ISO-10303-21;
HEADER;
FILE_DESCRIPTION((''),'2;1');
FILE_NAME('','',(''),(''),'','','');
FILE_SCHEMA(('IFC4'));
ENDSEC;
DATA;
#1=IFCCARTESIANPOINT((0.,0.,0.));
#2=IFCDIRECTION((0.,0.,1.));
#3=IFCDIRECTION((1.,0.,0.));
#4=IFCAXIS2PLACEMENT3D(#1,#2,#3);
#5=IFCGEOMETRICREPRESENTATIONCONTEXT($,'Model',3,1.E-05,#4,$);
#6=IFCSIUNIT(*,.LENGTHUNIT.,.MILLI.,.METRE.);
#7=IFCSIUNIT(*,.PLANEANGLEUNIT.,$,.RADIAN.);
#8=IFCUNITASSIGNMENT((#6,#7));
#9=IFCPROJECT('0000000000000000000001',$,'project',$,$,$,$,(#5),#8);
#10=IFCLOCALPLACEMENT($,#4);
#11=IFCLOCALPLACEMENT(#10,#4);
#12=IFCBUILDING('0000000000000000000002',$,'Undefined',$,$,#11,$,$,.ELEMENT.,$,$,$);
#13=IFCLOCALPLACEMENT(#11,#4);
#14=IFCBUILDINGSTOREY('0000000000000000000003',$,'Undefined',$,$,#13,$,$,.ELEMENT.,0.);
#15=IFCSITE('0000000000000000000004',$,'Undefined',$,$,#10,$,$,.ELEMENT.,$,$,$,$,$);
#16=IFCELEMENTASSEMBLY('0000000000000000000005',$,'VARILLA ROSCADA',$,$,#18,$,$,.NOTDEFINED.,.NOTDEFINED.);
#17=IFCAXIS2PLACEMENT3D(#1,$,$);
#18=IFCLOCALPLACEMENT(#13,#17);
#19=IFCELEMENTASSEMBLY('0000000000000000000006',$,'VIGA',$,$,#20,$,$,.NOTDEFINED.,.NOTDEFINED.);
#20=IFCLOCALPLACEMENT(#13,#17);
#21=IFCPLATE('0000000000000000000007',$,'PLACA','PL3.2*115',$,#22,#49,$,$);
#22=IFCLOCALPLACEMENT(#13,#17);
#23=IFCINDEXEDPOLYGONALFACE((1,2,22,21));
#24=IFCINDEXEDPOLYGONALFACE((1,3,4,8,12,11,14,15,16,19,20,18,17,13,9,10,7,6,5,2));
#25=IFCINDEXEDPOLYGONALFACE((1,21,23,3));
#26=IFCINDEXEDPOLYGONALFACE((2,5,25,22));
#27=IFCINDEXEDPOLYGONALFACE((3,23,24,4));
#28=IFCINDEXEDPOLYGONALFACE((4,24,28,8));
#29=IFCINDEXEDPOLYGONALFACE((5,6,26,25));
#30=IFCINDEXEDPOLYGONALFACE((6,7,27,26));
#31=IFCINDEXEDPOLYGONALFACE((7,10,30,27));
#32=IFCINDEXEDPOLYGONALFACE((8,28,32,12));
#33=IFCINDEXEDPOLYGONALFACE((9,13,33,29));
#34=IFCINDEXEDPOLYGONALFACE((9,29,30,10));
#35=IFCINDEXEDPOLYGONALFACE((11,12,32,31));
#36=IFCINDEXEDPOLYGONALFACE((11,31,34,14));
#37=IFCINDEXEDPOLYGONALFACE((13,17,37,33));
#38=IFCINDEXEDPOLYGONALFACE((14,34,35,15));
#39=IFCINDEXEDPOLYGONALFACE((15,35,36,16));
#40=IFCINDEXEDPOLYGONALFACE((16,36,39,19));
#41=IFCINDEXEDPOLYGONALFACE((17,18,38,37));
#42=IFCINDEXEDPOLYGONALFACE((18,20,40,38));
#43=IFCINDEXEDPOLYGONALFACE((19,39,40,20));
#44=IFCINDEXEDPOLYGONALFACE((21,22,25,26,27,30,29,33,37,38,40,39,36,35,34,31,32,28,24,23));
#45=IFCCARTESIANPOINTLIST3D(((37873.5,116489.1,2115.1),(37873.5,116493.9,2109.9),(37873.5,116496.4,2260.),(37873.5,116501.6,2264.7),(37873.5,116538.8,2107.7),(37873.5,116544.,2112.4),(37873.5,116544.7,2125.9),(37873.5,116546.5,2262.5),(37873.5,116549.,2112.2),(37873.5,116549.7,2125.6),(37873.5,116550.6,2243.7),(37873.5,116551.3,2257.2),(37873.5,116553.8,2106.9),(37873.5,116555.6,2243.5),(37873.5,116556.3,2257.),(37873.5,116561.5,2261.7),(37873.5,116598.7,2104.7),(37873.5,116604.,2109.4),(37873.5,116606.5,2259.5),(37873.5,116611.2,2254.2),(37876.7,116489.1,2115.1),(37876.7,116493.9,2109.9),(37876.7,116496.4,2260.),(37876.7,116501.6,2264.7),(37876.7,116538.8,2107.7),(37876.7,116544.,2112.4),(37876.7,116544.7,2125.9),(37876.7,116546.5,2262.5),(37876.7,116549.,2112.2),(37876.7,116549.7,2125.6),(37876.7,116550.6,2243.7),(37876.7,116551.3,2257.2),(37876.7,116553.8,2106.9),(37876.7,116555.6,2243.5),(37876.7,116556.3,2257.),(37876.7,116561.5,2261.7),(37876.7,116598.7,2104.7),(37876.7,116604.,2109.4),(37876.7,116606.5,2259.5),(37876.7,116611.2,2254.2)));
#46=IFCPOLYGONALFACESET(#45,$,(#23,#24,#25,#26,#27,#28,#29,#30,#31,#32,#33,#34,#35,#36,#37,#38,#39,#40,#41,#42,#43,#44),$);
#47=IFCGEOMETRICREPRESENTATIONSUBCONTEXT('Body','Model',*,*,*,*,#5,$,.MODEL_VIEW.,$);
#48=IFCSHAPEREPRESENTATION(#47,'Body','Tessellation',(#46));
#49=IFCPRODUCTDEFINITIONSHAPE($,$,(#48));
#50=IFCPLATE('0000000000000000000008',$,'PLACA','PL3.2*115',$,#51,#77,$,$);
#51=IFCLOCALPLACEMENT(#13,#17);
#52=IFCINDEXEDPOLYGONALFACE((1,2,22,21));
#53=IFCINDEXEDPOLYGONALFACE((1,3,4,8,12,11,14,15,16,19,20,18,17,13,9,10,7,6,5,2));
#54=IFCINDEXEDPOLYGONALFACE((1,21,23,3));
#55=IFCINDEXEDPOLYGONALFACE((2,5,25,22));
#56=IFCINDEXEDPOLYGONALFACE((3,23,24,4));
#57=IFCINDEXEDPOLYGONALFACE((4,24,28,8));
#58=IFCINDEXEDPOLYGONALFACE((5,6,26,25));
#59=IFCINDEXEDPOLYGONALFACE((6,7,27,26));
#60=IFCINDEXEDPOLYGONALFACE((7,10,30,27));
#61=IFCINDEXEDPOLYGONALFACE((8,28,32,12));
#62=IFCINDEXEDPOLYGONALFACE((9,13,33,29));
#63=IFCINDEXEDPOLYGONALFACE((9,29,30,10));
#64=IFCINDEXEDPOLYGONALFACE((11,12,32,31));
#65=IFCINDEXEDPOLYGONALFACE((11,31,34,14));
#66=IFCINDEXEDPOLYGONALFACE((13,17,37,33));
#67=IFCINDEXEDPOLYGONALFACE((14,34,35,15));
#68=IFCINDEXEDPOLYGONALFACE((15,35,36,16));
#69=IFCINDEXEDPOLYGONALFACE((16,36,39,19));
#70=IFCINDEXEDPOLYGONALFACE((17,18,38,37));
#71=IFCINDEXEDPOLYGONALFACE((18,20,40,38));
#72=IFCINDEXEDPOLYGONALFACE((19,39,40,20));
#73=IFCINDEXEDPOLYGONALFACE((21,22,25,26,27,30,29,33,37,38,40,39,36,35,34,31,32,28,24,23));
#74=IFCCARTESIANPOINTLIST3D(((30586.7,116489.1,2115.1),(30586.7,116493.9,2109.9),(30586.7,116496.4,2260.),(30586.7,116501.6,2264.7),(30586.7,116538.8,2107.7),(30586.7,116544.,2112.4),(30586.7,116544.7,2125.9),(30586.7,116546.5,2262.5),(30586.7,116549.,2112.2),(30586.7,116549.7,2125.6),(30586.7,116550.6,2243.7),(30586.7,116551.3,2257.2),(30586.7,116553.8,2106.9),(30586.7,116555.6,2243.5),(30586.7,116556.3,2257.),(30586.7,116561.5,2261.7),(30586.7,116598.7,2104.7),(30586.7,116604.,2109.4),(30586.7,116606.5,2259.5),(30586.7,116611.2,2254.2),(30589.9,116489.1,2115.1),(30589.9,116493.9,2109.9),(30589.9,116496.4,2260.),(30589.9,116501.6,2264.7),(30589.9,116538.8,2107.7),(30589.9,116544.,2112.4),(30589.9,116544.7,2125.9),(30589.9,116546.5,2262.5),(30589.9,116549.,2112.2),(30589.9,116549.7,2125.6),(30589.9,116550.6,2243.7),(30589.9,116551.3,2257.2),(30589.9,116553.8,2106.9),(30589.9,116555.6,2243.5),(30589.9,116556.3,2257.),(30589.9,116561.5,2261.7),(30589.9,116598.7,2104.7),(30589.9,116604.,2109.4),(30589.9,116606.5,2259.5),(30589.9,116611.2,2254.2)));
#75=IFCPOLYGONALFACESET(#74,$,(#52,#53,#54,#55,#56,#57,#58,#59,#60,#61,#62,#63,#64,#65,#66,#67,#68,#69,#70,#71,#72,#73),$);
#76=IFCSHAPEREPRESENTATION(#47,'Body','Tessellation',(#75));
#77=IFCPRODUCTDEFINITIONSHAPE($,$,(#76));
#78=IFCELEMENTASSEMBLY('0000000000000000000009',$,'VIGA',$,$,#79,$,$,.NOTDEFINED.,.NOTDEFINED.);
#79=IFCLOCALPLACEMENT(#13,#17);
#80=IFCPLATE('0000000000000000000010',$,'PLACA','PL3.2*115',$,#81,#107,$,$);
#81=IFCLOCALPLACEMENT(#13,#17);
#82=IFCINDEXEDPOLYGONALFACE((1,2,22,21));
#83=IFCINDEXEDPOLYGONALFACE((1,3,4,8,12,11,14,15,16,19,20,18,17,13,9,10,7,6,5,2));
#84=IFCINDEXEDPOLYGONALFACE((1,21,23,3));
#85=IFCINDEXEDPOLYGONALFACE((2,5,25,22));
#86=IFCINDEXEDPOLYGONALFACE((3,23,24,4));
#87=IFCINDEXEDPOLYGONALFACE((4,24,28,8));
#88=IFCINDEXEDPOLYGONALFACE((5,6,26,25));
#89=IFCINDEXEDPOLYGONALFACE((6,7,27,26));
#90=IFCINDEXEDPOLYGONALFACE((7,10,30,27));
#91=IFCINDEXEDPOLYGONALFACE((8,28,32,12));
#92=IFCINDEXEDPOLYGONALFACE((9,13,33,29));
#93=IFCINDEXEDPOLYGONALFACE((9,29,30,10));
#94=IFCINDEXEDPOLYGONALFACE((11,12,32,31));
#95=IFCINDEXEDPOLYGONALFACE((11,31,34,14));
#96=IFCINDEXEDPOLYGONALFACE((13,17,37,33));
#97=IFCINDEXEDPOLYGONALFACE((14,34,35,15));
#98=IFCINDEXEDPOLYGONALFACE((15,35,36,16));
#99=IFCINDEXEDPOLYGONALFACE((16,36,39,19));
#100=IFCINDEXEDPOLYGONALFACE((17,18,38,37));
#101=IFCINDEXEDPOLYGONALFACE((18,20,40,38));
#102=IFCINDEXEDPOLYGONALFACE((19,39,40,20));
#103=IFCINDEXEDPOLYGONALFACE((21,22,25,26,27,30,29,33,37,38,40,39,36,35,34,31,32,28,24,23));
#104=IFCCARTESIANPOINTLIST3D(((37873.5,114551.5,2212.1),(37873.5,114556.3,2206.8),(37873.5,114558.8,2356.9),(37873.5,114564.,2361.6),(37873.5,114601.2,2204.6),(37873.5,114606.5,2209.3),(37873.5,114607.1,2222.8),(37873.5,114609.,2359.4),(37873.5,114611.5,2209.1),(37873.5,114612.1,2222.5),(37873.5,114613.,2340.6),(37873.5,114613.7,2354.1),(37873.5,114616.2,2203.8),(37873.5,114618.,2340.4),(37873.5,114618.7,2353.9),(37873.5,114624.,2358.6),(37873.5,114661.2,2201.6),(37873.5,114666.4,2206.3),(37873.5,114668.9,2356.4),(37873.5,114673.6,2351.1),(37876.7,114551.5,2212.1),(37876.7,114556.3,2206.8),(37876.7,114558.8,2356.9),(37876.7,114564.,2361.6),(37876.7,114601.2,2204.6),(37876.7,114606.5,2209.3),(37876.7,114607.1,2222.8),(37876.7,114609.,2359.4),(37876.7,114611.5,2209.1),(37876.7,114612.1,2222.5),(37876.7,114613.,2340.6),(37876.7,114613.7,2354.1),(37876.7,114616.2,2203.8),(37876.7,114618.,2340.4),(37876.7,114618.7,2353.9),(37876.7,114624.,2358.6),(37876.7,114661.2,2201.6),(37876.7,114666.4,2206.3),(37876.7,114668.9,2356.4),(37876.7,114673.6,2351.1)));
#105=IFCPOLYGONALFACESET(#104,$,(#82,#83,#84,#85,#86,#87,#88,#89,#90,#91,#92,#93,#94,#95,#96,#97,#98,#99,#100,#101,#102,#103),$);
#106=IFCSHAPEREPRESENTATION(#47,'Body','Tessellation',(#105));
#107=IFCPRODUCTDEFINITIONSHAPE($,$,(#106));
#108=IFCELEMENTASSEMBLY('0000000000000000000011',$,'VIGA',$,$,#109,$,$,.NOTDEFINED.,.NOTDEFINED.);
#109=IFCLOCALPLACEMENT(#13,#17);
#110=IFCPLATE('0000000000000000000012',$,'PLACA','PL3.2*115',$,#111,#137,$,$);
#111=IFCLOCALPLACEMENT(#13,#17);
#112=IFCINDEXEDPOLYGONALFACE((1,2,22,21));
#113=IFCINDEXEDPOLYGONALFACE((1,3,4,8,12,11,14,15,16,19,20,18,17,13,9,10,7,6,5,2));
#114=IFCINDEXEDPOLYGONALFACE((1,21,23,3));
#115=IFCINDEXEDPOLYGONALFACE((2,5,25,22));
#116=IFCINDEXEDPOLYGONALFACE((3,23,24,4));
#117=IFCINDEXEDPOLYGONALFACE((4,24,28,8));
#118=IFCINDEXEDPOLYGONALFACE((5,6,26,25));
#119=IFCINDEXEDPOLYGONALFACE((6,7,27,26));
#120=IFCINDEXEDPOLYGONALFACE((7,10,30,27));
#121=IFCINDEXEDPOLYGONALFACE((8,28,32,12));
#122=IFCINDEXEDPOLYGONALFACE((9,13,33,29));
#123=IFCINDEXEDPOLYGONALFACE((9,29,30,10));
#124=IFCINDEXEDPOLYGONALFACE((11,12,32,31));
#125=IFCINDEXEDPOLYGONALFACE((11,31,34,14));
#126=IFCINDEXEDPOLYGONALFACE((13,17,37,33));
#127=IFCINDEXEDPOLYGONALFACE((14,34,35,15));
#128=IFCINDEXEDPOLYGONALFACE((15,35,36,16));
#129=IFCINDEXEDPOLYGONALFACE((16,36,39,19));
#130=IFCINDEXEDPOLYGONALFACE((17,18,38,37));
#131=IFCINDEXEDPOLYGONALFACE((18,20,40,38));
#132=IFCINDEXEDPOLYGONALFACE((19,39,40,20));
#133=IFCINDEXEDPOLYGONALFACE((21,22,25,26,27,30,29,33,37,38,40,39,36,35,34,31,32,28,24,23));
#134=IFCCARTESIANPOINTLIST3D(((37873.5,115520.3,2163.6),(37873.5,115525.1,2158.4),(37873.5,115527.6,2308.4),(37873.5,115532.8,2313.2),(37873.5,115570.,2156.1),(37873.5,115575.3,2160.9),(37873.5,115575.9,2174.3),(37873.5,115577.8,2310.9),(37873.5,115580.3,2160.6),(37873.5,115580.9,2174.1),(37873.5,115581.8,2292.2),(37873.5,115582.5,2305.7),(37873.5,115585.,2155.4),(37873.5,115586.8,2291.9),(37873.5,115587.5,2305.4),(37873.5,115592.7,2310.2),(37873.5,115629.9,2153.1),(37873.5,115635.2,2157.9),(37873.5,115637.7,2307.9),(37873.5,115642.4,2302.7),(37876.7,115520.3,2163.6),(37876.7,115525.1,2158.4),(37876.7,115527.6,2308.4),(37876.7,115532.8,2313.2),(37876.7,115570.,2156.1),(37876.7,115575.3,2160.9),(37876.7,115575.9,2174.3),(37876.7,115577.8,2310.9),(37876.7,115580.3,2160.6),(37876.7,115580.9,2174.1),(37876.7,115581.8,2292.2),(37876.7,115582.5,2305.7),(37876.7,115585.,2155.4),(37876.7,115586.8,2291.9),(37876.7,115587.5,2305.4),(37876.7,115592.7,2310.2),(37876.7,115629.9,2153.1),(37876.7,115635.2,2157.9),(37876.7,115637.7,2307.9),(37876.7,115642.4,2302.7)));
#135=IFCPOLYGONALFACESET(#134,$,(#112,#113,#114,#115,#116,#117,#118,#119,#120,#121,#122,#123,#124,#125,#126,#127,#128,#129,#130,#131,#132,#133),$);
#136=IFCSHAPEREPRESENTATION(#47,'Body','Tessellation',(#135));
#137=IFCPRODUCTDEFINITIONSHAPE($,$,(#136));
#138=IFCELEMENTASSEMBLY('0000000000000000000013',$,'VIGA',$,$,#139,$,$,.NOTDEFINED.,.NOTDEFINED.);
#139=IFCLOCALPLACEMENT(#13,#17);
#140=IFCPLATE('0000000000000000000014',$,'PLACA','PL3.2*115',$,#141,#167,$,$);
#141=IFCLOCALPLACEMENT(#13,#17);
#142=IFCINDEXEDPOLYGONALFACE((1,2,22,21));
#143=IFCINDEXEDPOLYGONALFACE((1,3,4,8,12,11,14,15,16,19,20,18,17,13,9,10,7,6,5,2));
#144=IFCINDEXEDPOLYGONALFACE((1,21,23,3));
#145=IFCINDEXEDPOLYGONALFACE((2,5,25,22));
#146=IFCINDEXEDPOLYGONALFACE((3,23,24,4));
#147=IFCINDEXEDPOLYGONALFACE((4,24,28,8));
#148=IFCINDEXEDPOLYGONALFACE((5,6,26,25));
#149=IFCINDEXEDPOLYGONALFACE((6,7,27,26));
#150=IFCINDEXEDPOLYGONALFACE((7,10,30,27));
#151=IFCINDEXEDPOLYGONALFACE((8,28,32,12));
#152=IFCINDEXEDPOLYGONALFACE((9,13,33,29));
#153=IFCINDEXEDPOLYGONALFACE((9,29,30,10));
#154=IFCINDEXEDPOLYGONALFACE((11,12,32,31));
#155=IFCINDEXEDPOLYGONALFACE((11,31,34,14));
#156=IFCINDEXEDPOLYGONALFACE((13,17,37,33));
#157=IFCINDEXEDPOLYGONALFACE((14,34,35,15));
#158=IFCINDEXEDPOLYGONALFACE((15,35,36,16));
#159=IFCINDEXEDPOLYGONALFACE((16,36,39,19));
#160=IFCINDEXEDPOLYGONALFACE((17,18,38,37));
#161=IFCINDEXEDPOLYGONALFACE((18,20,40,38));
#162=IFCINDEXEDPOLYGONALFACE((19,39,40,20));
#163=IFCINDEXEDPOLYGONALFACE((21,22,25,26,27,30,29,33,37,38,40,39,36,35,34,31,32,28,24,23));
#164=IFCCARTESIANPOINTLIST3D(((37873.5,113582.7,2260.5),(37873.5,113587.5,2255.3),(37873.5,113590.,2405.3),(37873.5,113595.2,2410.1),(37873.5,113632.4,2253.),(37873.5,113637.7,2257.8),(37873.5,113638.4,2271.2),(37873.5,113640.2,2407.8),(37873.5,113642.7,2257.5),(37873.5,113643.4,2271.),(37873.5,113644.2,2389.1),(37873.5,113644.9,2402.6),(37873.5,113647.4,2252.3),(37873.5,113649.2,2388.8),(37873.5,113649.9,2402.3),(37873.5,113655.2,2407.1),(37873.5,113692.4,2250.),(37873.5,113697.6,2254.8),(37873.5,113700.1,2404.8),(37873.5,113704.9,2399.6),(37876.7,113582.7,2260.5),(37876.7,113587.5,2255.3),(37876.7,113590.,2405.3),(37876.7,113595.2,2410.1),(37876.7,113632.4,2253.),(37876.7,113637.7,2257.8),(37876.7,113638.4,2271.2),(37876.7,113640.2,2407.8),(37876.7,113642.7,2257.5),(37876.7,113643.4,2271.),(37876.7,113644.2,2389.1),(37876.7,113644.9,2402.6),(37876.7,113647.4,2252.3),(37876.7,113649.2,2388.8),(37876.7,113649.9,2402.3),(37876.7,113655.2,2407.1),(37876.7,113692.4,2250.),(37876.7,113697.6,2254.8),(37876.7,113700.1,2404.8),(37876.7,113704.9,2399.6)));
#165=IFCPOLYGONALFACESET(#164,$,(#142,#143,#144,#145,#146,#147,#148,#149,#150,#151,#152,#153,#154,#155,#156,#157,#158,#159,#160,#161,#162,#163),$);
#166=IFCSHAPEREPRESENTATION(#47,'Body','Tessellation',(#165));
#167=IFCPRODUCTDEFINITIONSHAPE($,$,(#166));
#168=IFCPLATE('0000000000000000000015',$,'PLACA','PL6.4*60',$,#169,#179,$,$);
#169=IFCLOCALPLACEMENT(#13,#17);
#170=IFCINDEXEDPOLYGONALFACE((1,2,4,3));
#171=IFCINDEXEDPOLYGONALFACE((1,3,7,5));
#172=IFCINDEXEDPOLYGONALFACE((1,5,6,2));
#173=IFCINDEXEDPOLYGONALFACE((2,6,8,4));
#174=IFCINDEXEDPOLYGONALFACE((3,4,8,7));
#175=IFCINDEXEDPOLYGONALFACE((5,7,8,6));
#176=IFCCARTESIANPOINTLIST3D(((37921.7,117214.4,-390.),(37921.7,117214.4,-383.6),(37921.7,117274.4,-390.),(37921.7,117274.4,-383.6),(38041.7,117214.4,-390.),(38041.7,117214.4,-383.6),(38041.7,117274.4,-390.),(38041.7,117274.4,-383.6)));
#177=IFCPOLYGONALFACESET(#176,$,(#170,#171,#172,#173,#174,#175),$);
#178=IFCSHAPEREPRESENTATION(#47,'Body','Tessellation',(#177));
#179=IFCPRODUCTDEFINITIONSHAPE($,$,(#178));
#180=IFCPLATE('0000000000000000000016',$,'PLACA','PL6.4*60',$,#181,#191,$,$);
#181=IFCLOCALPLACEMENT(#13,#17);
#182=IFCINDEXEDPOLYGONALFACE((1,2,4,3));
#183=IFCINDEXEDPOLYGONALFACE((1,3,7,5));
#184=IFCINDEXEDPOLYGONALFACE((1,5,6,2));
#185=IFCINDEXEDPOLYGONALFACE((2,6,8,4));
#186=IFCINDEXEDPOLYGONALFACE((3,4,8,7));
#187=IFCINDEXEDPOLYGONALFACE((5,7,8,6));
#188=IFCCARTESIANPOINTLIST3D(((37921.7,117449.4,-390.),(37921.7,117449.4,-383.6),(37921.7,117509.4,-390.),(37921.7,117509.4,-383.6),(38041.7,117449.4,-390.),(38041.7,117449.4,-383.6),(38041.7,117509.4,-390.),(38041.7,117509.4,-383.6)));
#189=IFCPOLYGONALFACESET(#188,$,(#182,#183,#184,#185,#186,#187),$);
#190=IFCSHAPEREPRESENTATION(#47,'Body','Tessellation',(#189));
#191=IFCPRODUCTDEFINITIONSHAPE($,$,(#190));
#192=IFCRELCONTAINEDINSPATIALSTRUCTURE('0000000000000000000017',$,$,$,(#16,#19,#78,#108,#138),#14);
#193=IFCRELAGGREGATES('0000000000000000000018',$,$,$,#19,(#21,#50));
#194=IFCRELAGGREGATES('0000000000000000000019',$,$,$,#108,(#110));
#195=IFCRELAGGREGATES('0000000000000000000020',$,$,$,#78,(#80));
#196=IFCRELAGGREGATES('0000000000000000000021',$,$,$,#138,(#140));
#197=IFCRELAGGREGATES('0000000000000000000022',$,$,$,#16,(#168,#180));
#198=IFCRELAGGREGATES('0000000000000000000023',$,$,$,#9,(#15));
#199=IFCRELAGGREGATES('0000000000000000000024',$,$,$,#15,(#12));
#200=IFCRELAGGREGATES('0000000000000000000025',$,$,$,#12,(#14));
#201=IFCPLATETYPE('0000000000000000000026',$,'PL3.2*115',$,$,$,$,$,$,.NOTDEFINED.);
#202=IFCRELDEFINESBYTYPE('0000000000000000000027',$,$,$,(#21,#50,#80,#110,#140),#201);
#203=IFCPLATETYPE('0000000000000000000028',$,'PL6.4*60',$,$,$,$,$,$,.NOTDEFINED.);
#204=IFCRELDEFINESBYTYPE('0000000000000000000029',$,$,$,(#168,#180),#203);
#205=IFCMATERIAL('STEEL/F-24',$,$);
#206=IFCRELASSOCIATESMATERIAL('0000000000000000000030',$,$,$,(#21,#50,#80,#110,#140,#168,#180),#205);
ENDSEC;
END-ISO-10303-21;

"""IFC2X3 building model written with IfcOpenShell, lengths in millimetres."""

from ifc_helpers import new_model, si_unit, frame, origin_with_axes, place, context, subcontext, project, spatial, polyline, outline, extrude, material, type_object, element, aggregate, save


model = new_model("IFC2X3")

# Units and contexts
model_context = context("Model", 3, precision=1e-05, world=origin_with_axes())
body_context = subcontext(model_context, "Body", "Model", "MODEL_VIEW")
ifc_project = project(units=[si_unit("LENGTHUNIT", "METRE", prefix="MILLI"), si_unit("PLANEANGLEUNIT", "RADIAN")], contexts=[model_context])

# Site, building, storey
site_placement = place(None, origin_with_axes())
site = spatial("IfcSite", under=ifc_project, at=site_placement, Name="Undefined", CompositionType="ELEMENT")
building_placement = place(site_placement, origin_with_axes())
building = spatial("IfcBuilding", under=site, at=building_placement, Name="Undefined", CompositionType="ELEMENT")
storey_placement = place(building_placement, origin_with_axes())
storey = spatial("IfcBuildingStorey", under=building, at=storey_placement, Name="Undefined", CompositionType="ELEMENT", Elevation=0.0)

# Element assembly
assembly_1_placement = place(storey_placement, origin_with_axes())
assembly_1 = element("IfcElementAssembly", 1, at=assembly_1_placement, inside=storey, Name="VARILLA ROSCADA", AssemblyPlace="NOTDEFINED", PredefinedType="NOTDEFINED")

# Shared definitions
ifc_material_1 = material(Name="STEEL/F-24")

# Element assembly, plates
plate_type_1 = type_object("IfcPlateType", Name="PL3.2*115", PredefinedType="NOTDEFINED")
assembly_2_placement = place(storey_placement, origin_with_axes())
assembly_2 = element("IfcElementAssembly", 2, at=assembly_2_placement, inside=storey, Name="VIGA", AssemblyPlace="NOTDEFINED", PredefinedType="NOTDEFINED")
plate_1_placement = place(assembly_2_placement, frame((37875.1, 116611.5, 2259.2), z_axis=(1.0, 0.0, 0.0), x_axis=(0.0, -0.998752, 0.04995)))
plate_1 = element("IfcPlate", 3, at=plate_1_placement, type_object=plate_type_1, material=ifc_material_1, Name="PLACA", Description="PL3.2*115", context=body_context, shape_type="SweptSolid", body=[
    extrude(outline(polyline([(0.0, 5.0), (5.0, 0.0), (50.0, 0.0), (55.0, 5.0), (55.0, 18.5), (60.0, 18.5), (60.0, 5.0), (65.0, 0.0), (110.0, 0.0), (115.0, 5.0), (115.0, 150.0), (110.0, 155.0), (65.0, 155.0), (60.0, 150.0), (60.0, 136.5), (55.0, 136.5), (55.0, 150.0), (50.0, 155.0), (5.0, 155.0), (0.0, 150.0), (0.0, 5.0)])), frame((0.0, 0.0, -1.6), z_axis=(0.0, 0.0, 1.0), x_axis=(1.0, 0.0, 0.0)), (0.0, 0.0, 1.0), 3.2),
])
plate_2_placement = place(assembly_2_placement, frame((30588.3, 116611.5, 2259.2), z_axis=(1.0, 0.0, 0.0), x_axis=(0.0, -0.998752, 0.04995)))
plate_2 = element("IfcPlate", 4, at=plate_2_placement, type_object=plate_type_1, material=ifc_material_1, Name="PLACA", Description="PL3.2*115", context=body_context, shape_type="SweptSolid", body=[
    extrude(outline(polyline([(0.0, 5.0), (5.0, 0.0), (50.0, 0.0), (55.0, 5.0), (55.0, 18.5), (60.0, 18.5), (60.0, 5.0), (65.0, 0.0), (110.0, 0.0), (115.0, 5.0), (115.0, 150.0), (110.0, 155.0), (65.0, 155.0), (60.0, 150.0), (60.0, 136.5), (55.0, 136.5), (55.0, 150.0), (50.0, 155.0), (5.0, 155.0), (0.0, 150.0), (0.0, 5.0)])), frame((0.0, 0.0, -1.6), z_axis=(0.0, 0.0, 1.0), x_axis=(1.0, 0.0, 0.0)), (0.0, 0.0, 1.0), 3.2),
])

# Element assemblies, plates
assembly_3_placement = place(storey_placement, origin_with_axes())
assembly_3 = element("IfcElementAssembly", 5, at=assembly_3_placement, inside=storey, Name="VIGA", AssemblyPlace="NOTDEFINED", PredefinedType="NOTDEFINED")
plate_3_placement = place(assembly_3_placement, frame((37875.1, 114673.9, 2356.1), z_axis=(1.0, 0.0, 0.0), x_axis=(0.0, -0.998752, 0.04995)))
plate_3 = element("IfcPlate", 6, at=plate_3_placement, type_object=plate_type_1, material=ifc_material_1, Name="PLACA", Description="PL3.2*115", context=body_context, shape_type="SweptSolid", body=[
    extrude(outline(polyline([(0.0, 5.0), (5.0, 0.0), (50.0, 0.0), (55.0, 5.0), (55.0, 18.5), (60.0, 18.5), (60.0, 5.0), (65.0, 0.0), (110.0, 0.0), (115.0, 5.0), (115.0, 150.0), (110.0, 155.0), (65.0, 155.0), (60.0, 150.0), (60.0, 136.5), (55.0, 136.5), (55.0, 150.0), (50.0, 155.0), (5.0, 155.0), (0.0, 150.0), (0.0, 5.0)])), frame((0.0, 0.0, -1.6), z_axis=(0.0, 0.0, 1.0), x_axis=(1.0, 0.0, 0.0)), (0.0, 0.0, 1.0), 3.2),
])
assembly_4_placement = place(storey_placement, origin_with_axes())
assembly_4 = element("IfcElementAssembly", 7, at=assembly_4_placement, inside=storey, Name="VIGA", AssemblyPlace="NOTDEFINED", PredefinedType="NOTDEFINED")
plate_4_placement = place(assembly_4_placement, frame((37875.1, 115642.7, 2307.7), z_axis=(1.0, 0.0, 0.0), x_axis=(0.0, -0.998752, 0.04995)))
plate_4 = element("IfcPlate", 8, at=plate_4_placement, type_object=plate_type_1, material=ifc_material_1, Name="PLACA", Description="PL3.2*115", context=body_context, shape_type="SweptSolid", body=[
    extrude(outline(polyline([(0.0, 5.0), (5.0, 0.0), (50.0, 0.0), (55.0, 5.0), (55.0, 18.5), (60.0, 18.5), (60.0, 5.0), (65.0, 0.0), (110.0, 0.0), (115.0, 5.0), (115.0, 150.0), (110.0, 155.0), (65.0, 155.0), (60.0, 150.0), (60.0, 136.5), (55.0, 136.5), (55.0, 150.0), (50.0, 155.0), (5.0, 155.0), (0.0, 150.0), (0.0, 5.0)])), frame((0.0, 0.0, -1.6), z_axis=(0.0, 0.0, 1.0), x_axis=(1.0, 0.0, 0.0)), (0.0, 0.0, 1.0), 3.2),
])
assembly_5_placement = place(storey_placement, origin_with_axes())
assembly_5 = element("IfcElementAssembly", 9, at=assembly_5_placement, inside=storey, Name="VIGA", AssemblyPlace="NOTDEFINED", PredefinedType="NOTDEFINED")
plate_5_placement = place(assembly_5_placement, frame((37875.1, 113705.1, 2404.6), z_axis=(1.0, 0.0, 0.0), x_axis=(0.0, -0.998752, 0.04995)))
plate_5 = element("IfcPlate", 10, at=plate_5_placement, type_object=plate_type_1, material=ifc_material_1, Name="PLACA", Description="PL3.2*115", context=body_context, shape_type="SweptSolid", body=[
    extrude(outline(polyline([(0.0, 5.0), (5.0, 0.0), (50.0, 0.0), (55.0, 5.0), (55.0, 18.5), (60.0, 18.5), (60.0, 5.0), (65.0, 0.0), (110.0, 0.0), (115.0, 5.0), (115.0, 150.0), (110.0, 155.0), (65.0, 155.0), (60.0, 150.0), (60.0, 136.5), (55.0, 136.5), (55.0, 150.0), (50.0, 155.0), (5.0, 155.0), (0.0, 150.0), (0.0, 5.0)])), frame((0.0, 0.0, -1.6), z_axis=(0.0, 0.0, 1.0), x_axis=(1.0, 0.0, 0.0)), (0.0, 0.0, 1.0), 3.2),
])

# Plates
plate_type_2 = type_object("IfcPlateType", Name="PL6.4*60", PredefinedType="NOTDEFINED")
plate_6_placement = place(assembly_1_placement, frame((37921.7, 117214.4, -386.8), z_axis=(0.0, 0.0, 1.0), x_axis=(1.0, 0.0, 0.0)))
plate_6 = element("IfcPlate", 11, at=plate_6_placement, type_object=plate_type_2, material=ifc_material_1, Name="PLACA", Description="PL6.4*60", context=body_context, shape_type="SweptSolid", body=[
    extrude(outline(polyline([(0.0, 0.0), (120.0, 0.0), (120.0, 60.0), (0.0, 60.0), (0.0, 0.0)])), frame((0.0, 0.0, -3.2), z_axis=(0.0, 0.0, 1.0), x_axis=(1.0, 0.0, 0.0)), (0.0, 0.0, 1.0), 6.4),
])
plate_7_placement = place(assembly_1_placement, frame((37921.7, 117449.4, -386.8), z_axis=(0.0, 0.0, 1.0), x_axis=(1.0, 0.0, 0.0)))
plate_7 = element("IfcPlate", 12, at=plate_7_placement, type_object=plate_type_2, material=ifc_material_1, Name="PLACA", Description="PL6.4*60", context=body_context, shape_type="SweptSolid", body=[
    extrude(outline(polyline([(0.0, 0.0), (120.0, 0.0), (120.0, 60.0), (0.0, 60.0), (0.0, 0.0)])), frame((0.0, 0.0, -3.2), z_axis=(0.0, 0.0, 1.0), x_axis=(1.0, 0.0, 0.0)), (0.0, 0.0, 1.0), 6.4),
])

aggregate(assembly_2, [plate_1, plate_2])
aggregate(assembly_4, [plate_4])
aggregate(assembly_3, [plate_3])
aggregate(assembly_5, [plate_5])
aggregate(assembly_1, [plate_6, plate_7])

save(model, "model.ifc")
